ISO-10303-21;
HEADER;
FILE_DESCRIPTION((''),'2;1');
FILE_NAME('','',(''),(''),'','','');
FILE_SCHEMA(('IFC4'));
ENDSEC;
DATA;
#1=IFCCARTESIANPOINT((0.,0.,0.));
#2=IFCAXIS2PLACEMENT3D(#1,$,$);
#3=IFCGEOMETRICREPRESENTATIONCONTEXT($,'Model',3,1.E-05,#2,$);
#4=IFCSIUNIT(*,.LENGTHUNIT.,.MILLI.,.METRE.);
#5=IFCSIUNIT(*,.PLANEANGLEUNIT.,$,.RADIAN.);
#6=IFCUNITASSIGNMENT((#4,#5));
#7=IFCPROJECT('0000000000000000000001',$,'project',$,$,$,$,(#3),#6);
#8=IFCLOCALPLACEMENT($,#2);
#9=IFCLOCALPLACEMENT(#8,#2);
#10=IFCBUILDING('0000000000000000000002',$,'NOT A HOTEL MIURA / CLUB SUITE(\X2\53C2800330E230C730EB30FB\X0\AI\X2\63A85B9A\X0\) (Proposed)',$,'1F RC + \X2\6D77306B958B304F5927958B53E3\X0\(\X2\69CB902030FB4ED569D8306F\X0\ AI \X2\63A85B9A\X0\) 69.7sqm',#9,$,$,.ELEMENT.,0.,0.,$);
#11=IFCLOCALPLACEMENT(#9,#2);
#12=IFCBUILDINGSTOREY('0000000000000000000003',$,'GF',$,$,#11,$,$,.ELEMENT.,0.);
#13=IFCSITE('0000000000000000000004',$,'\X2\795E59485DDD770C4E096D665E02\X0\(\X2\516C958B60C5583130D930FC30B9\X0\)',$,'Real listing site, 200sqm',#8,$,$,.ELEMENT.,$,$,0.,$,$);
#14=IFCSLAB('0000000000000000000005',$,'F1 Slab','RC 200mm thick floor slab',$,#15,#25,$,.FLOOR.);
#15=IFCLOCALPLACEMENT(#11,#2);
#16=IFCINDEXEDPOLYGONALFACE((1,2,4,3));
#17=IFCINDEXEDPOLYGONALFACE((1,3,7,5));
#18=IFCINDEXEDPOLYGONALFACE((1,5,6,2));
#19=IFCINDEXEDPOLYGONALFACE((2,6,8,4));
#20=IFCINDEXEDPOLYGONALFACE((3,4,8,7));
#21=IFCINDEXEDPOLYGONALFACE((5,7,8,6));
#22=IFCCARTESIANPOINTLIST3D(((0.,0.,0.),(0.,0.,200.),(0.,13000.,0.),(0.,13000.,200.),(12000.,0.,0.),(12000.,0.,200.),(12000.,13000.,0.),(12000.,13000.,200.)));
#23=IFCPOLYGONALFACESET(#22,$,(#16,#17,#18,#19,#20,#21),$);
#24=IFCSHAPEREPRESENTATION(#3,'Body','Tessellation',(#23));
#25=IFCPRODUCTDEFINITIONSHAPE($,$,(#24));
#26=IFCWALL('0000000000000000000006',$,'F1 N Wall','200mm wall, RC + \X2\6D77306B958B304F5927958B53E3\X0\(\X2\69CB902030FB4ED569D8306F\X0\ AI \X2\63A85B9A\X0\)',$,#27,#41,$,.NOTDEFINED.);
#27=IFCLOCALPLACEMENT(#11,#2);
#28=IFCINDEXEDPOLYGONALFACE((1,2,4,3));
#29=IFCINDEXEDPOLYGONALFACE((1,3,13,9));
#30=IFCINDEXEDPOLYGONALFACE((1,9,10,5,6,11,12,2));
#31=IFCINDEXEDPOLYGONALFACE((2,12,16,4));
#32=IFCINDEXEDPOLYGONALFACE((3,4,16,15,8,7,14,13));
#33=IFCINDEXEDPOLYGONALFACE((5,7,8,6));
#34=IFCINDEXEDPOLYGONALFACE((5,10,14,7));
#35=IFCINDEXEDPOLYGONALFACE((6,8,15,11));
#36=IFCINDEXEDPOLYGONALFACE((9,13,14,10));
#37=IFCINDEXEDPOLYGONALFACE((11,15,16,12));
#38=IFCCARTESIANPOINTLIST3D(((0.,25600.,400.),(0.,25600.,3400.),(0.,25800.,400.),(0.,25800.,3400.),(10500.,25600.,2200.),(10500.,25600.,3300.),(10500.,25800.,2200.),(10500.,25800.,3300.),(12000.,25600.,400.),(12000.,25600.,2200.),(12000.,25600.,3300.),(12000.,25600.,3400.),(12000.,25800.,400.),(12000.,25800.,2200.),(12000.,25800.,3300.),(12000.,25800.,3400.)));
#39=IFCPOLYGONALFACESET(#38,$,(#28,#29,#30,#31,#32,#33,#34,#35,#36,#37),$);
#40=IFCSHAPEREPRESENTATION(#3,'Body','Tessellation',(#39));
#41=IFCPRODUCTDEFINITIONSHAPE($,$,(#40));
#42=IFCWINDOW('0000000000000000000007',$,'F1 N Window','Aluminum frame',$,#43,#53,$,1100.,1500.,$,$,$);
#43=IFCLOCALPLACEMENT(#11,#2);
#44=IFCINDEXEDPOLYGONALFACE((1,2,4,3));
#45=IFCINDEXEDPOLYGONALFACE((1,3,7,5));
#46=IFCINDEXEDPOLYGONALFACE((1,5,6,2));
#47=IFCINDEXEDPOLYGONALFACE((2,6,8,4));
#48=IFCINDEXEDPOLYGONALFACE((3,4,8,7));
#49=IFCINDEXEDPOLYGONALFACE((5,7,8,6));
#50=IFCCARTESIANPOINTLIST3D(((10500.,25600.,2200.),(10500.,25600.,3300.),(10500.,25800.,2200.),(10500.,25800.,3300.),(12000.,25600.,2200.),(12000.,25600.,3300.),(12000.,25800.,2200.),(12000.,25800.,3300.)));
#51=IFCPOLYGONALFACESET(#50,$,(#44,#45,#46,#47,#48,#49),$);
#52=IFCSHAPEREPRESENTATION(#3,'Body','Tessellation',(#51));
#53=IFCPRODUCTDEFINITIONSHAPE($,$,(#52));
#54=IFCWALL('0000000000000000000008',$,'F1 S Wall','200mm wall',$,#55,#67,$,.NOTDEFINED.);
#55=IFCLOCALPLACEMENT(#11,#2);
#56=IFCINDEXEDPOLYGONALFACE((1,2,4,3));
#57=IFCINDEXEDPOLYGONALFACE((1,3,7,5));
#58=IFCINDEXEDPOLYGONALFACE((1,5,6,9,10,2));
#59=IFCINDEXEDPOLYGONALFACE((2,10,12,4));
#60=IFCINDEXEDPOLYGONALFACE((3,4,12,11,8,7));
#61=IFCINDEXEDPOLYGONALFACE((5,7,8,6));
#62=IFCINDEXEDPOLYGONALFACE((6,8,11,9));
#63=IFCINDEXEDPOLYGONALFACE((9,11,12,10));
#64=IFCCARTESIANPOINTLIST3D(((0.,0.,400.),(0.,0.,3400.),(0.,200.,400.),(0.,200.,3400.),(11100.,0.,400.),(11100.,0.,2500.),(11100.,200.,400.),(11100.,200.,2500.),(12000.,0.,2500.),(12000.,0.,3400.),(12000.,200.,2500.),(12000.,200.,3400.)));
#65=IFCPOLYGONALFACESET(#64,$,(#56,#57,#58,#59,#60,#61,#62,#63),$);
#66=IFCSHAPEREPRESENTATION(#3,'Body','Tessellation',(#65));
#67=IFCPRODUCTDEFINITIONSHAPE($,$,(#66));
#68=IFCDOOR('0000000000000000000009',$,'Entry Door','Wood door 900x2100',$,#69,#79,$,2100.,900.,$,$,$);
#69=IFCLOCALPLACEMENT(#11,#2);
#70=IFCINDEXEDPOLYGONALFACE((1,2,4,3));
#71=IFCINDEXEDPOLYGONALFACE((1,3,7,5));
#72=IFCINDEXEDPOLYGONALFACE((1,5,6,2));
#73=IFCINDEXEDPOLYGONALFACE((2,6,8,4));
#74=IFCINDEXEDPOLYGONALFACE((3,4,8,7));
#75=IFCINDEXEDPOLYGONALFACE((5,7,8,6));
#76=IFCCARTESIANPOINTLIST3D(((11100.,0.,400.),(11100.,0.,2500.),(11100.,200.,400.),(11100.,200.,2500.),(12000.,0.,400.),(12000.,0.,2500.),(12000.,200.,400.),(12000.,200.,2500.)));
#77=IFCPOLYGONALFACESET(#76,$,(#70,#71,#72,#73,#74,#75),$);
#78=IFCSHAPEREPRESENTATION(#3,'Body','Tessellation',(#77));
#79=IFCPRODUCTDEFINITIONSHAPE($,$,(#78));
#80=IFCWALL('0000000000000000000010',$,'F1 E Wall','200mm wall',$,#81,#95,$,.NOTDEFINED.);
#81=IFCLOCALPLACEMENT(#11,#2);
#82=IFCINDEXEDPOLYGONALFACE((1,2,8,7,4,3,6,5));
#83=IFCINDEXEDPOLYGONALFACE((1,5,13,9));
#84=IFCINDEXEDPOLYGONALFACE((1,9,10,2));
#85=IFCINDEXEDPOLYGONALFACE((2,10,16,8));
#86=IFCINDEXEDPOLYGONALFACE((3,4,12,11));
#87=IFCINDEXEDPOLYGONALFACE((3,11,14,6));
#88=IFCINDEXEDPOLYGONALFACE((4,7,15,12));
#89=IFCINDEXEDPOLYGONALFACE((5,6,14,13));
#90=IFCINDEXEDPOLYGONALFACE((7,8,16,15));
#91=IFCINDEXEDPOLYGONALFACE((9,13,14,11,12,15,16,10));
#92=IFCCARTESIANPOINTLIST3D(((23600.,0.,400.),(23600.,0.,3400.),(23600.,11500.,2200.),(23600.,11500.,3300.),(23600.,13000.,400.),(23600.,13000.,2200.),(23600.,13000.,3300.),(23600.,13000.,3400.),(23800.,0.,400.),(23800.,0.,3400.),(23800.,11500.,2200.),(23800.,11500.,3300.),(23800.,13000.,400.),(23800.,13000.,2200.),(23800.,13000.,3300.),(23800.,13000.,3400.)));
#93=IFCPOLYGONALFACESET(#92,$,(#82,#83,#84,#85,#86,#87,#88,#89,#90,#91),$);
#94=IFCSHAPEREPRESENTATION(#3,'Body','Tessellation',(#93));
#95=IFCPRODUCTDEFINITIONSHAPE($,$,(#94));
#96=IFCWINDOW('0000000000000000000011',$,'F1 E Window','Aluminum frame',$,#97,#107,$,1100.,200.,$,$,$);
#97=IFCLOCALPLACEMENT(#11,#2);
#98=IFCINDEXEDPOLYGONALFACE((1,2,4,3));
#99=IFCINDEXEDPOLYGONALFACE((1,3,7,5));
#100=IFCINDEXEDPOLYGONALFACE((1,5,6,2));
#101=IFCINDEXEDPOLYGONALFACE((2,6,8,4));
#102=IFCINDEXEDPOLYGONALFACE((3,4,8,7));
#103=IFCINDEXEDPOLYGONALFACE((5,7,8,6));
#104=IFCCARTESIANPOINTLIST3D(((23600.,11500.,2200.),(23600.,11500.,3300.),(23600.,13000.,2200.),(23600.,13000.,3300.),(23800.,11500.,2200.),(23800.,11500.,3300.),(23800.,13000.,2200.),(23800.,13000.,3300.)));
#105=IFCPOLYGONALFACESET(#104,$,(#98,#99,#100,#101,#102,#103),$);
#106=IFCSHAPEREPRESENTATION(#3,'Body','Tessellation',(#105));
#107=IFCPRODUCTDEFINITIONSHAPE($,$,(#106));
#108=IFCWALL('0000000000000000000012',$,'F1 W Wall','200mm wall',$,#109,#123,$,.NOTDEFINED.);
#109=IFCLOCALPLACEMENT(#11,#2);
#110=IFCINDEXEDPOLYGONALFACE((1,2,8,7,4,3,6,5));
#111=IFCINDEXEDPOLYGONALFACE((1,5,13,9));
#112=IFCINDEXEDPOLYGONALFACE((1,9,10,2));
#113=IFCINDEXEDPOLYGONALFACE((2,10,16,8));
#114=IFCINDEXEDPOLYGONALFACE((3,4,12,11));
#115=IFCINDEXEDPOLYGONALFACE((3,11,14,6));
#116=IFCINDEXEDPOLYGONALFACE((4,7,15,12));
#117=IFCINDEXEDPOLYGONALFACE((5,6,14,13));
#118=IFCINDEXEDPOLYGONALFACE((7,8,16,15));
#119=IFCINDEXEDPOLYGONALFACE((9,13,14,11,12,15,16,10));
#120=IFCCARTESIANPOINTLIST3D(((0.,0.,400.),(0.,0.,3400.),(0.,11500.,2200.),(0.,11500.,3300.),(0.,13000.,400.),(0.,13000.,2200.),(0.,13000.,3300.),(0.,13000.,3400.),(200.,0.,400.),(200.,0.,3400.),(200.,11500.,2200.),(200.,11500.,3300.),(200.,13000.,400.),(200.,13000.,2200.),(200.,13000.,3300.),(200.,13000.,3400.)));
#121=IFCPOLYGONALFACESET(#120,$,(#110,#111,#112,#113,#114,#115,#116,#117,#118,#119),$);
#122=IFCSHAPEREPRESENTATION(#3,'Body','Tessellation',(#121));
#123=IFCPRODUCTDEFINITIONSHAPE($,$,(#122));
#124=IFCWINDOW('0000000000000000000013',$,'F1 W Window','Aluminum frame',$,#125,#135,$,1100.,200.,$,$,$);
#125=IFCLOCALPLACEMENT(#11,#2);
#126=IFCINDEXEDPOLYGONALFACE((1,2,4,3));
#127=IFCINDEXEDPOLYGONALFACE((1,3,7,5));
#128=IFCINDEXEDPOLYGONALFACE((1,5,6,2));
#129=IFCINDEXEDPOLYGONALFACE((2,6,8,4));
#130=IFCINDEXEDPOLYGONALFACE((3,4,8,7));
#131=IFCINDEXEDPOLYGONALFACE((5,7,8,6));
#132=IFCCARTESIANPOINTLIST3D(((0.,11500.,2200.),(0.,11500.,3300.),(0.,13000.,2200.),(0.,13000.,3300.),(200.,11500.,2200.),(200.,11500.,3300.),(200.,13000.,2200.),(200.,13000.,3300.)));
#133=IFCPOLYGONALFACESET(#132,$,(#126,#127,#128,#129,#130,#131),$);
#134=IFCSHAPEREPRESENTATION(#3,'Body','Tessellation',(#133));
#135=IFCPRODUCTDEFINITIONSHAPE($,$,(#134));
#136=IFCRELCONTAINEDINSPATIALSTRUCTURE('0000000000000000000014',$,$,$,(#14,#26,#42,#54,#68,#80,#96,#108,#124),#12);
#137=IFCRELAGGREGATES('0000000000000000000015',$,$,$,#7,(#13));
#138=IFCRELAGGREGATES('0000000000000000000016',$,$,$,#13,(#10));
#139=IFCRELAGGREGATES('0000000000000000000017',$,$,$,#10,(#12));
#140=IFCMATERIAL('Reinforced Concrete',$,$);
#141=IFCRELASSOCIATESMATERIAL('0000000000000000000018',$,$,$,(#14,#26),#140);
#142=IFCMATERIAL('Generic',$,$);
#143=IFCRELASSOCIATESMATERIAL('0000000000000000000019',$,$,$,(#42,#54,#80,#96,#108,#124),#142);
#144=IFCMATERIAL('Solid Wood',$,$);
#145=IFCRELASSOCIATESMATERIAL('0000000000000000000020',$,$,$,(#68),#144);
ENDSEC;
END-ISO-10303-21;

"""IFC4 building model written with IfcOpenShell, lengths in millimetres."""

from ifc_helpers import new_model, si_unit, frame, frame_2d, origin, place, context, project, spatial, rectangle, extrude, material, element, fill, save


model = new_model("IFC4")

# Units and contexts
model_context = context("Model", 3, precision=1e-05, world=origin())
ifc_project = project(units=[si_unit("LENGTHUNIT", "METRE", prefix="MILLI"), si_unit("PLANEANGLEUNIT", "RADIAN")], contexts=[model_context])

# Site, building, storey
site_placement = place(None, origin())
site = spatial("IfcSite", under=ifc_project, at=site_placement, Name="神奈川県三浦市(公開情報ベース)", ObjectType="Real listing site, 200sqm", CompositionType="ELEMENT", RefElevation=0.0)
building_placement = place(site_placement, origin())
building = spatial("IfcBuilding", under=site, at=building_placement, Name="NOT A HOTEL MIURA / CLUB SUITE(参考モデル・AI推定) (Proposed)", ObjectType="1F RC + 海に開く大開口(構造・仕様は AI 推定) 69.7sqm", CompositionType="ELEMENT", ElevationOfRefHeight=0.0, ElevationOfTerrain=0.0)
storey_placement = place(building_placement, origin())
storey = spatial("IfcBuildingStorey", under=building, at=storey_placement, Name="GF", CompositionType="ELEMENT", Elevation=0.0)

# Slab
ifc_material_1 = material(Name="Reinforced Concrete")
slab_placement = place(storey_placement, origin())
element("IfcSlab", 1, at=slab_placement, inside=storey, material=ifc_material_1, Name="F1 Slab", Description="RC 200mm thick floor slab", PredefinedType="FLOOR", context=model_context, shape_type="SweptSolid", body=[
    extrude(rectangle(XDim=12000.0, YDim=13000.0, at=frame_2d((6000.0, 6500.0))), origin(), (0.0, 0.0, 1.0), 200.0),
])

# Wall, opening, window
wall_1_placement = place(storey_placement, frame((0.0, 12800.0, 200.0)))
wall_1 = element("IfcWall", 2, at=wall_1_placement, inside=storey, material=ifc_material_1, Name="F1 N Wall", Description="200mm wall, RC + 海に開く大開口(構造・仕様は AI 推定)", PredefinedType="NOTDEFINED", context=model_context, shape_type="SweptSolid", body=[
    extrude(rectangle(XDim=12000.0, YDim=200.0, at=frame_2d((6000.0, 100.0))), frame((0.0, 12800.0, 200.0)), (0.0, 0.0, 1.0), 3000.0),
])
opening_1_placement = place(storey_placement, frame((5250.0, 12800.0, 1100.0)))
opening_1 = element("IfcOpeningElement", 3, at=opening_1_placement, cuts=wall_1, PredefinedType="NOTDEFINED", context=model_context, shape_type="SweptSolid", body=[
    extrude(rectangle(XDim=1500.0, YDim=200.0, at=frame_2d((750.0, 100.0))), frame((5250.0, 12800.0, 1100.0)), (0.0, 0.0, 1.0), 1100.0),
])
ifc_material_2 = material(Name="Generic")
window_1_placement = place(storey_placement, frame((5250.0, 12800.0, 1100.0)))
window_1 = element("IfcWindow", 4, at=window_1_placement, inside=storey, material=ifc_material_2, Name="F1 N Window", Description="Aluminum frame", OverallHeight=1100.0, OverallWidth=1500.0, context=model_context, shape_type="SweptSolid", body=[
    extrude(rectangle(XDim=1500.0, YDim=200.0, at=frame_2d((750.0, 100.0))), frame((5250.0, 12800.0, 1100.0)), (0.0, 0.0, 1.0), 1100.0),
])
fill(opening_1, window_1)

# Wall, opening, door
wall_2_placement = place(storey_placement, frame((0.0, 0.0, 200.0)))
wall_2 = element("IfcWall", 5, at=wall_2_placement, inside=storey, material=ifc_material_2, Name="F1 S Wall", Description="200mm wall", PredefinedType="NOTDEFINED", context=model_context, shape_type="SweptSolid", body=[
    extrude(rectangle(XDim=12000.0, YDim=200.0, at=frame_2d((6000.0, 100.0))), frame((0.0, 0.0, 200.0)), (0.0, 0.0, 1.0), 3000.0),
])
opening_2_placement = place(storey_placement, frame((5550.0, 0.0, 200.0)))
opening_2 = element("IfcOpeningElement", 6, at=opening_2_placement, cuts=wall_2, PredefinedType="NOTDEFINED", context=model_context, shape_type="SweptSolid", body=[
    extrude(rectangle(XDim=900.0, YDim=200.0, at=frame_2d((450.0, 100.0))), frame((5550.0, 0.0, 200.0)), (0.0, 0.0, 1.0), 2100.0),
])
ifc_material_3 = material(Name="Solid Wood")
door_placement = place(storey_placement, frame((5550.0, 0.0, 200.0)))
door = element("IfcDoor", 7, at=door_placement, inside=storey, material=ifc_material_3, Name="Entry Door", Description="Wood door 900x2100", OverallHeight=2100.0, OverallWidth=900.0, context=model_context, shape_type="SweptSolid", body=[
    extrude(rectangle(XDim=900.0, YDim=200.0, at=frame_2d((450.0, 100.0))), frame((5550.0, 0.0, 200.0)), (0.0, 0.0, 1.0), 2100.0),
])
fill(opening_2, door)

# Walls, openings, windows
wall_3_placement = place(storey_placement, frame((11800.0, 0.0, 200.0)))
wall_3 = element("IfcWall", 8, at=wall_3_placement, inside=storey, material=ifc_material_2, Name="F1 E Wall", Description="200mm wall", PredefinedType="NOTDEFINED", context=model_context, shape_type="SweptSolid", body=[
    extrude(rectangle(XDim=200.0, YDim=13000.0, at=frame_2d((100.0, 6500.0))), frame((11800.0, 0.0, 200.0)), (0.0, 0.0, 1.0), 3000.0),
])
opening_3_placement = place(storey_placement, frame((11800.0, 5750.0, 1100.0)))
opening_3 = element("IfcOpeningElement", 9, at=opening_3_placement, cuts=wall_3, PredefinedType="NOTDEFINED", context=model_context, shape_type="SweptSolid", body=[
    extrude(rectangle(XDim=200.0, YDim=1500.0, at=frame_2d((100.0, 750.0))), frame((11800.0, 5750.0, 1100.0)), (0.0, 0.0, 1.0), 1100.0),
])
window_2_placement = place(storey_placement, frame((11800.0, 5750.0, 1100.0)))
window_2 = element("IfcWindow", 10, at=window_2_placement, inside=storey, material=ifc_material_2, Name="F1 E Window", Description="Aluminum frame", OverallHeight=1100.0, OverallWidth=200.0, context=model_context, shape_type="SweptSolid", body=[
    extrude(rectangle(XDim=200.0, YDim=1500.0, at=frame_2d((100.0, 750.0))), frame((11800.0, 5750.0, 1100.0)), (0.0, 0.0, 1.0), 1100.0),
])
fill(opening_3, window_2)
wall_4_placement = place(storey_placement, frame((0.0, 0.0, 200.0)))
wall_4 = element("IfcWall", 11, at=wall_4_placement, inside=storey, material=ifc_material_2, Name="F1 W Wall", Description="200mm wall", PredefinedType="NOTDEFINED", context=model_context, shape_type="SweptSolid", body=[
    extrude(rectangle(XDim=200.0, YDim=13000.0, at=frame_2d((100.0, 6500.0))), frame((0.0, 0.0, 200.0)), (0.0, 0.0, 1.0), 3000.0),
])
opening_4_placement = place(storey_placement, frame((0.0, 5750.0, 1100.0)))
opening_4 = element("IfcOpeningElement", 12, at=opening_4_placement, cuts=wall_4, PredefinedType="NOTDEFINED", context=model_context, shape_type="SweptSolid", body=[
    extrude(rectangle(XDim=200.0, YDim=1500.0, at=frame_2d((100.0, 750.0))), frame((0.0, 5750.0, 1100.0)), (0.0, 0.0, 1.0), 1100.0),
])
window_3_placement = place(storey_placement, frame((0.0, 5750.0, 1100.0)))
window_3 = element("IfcWindow", 13, at=window_3_placement, inside=storey, material=ifc_material_2, Name="F1 W Window", Description="Aluminum frame", OverallHeight=1100.0, OverallWidth=200.0, context=model_context, shape_type="SweptSolid", body=[
    extrude(rectangle(XDim=200.0, YDim=1500.0, at=frame_2d((100.0, 750.0))), frame((0.0, 5750.0, 1100.0)), (0.0, 0.0, 1.0), 1100.0),
])
fill(opening_4, window_3)

save(model, "model.ifc")
